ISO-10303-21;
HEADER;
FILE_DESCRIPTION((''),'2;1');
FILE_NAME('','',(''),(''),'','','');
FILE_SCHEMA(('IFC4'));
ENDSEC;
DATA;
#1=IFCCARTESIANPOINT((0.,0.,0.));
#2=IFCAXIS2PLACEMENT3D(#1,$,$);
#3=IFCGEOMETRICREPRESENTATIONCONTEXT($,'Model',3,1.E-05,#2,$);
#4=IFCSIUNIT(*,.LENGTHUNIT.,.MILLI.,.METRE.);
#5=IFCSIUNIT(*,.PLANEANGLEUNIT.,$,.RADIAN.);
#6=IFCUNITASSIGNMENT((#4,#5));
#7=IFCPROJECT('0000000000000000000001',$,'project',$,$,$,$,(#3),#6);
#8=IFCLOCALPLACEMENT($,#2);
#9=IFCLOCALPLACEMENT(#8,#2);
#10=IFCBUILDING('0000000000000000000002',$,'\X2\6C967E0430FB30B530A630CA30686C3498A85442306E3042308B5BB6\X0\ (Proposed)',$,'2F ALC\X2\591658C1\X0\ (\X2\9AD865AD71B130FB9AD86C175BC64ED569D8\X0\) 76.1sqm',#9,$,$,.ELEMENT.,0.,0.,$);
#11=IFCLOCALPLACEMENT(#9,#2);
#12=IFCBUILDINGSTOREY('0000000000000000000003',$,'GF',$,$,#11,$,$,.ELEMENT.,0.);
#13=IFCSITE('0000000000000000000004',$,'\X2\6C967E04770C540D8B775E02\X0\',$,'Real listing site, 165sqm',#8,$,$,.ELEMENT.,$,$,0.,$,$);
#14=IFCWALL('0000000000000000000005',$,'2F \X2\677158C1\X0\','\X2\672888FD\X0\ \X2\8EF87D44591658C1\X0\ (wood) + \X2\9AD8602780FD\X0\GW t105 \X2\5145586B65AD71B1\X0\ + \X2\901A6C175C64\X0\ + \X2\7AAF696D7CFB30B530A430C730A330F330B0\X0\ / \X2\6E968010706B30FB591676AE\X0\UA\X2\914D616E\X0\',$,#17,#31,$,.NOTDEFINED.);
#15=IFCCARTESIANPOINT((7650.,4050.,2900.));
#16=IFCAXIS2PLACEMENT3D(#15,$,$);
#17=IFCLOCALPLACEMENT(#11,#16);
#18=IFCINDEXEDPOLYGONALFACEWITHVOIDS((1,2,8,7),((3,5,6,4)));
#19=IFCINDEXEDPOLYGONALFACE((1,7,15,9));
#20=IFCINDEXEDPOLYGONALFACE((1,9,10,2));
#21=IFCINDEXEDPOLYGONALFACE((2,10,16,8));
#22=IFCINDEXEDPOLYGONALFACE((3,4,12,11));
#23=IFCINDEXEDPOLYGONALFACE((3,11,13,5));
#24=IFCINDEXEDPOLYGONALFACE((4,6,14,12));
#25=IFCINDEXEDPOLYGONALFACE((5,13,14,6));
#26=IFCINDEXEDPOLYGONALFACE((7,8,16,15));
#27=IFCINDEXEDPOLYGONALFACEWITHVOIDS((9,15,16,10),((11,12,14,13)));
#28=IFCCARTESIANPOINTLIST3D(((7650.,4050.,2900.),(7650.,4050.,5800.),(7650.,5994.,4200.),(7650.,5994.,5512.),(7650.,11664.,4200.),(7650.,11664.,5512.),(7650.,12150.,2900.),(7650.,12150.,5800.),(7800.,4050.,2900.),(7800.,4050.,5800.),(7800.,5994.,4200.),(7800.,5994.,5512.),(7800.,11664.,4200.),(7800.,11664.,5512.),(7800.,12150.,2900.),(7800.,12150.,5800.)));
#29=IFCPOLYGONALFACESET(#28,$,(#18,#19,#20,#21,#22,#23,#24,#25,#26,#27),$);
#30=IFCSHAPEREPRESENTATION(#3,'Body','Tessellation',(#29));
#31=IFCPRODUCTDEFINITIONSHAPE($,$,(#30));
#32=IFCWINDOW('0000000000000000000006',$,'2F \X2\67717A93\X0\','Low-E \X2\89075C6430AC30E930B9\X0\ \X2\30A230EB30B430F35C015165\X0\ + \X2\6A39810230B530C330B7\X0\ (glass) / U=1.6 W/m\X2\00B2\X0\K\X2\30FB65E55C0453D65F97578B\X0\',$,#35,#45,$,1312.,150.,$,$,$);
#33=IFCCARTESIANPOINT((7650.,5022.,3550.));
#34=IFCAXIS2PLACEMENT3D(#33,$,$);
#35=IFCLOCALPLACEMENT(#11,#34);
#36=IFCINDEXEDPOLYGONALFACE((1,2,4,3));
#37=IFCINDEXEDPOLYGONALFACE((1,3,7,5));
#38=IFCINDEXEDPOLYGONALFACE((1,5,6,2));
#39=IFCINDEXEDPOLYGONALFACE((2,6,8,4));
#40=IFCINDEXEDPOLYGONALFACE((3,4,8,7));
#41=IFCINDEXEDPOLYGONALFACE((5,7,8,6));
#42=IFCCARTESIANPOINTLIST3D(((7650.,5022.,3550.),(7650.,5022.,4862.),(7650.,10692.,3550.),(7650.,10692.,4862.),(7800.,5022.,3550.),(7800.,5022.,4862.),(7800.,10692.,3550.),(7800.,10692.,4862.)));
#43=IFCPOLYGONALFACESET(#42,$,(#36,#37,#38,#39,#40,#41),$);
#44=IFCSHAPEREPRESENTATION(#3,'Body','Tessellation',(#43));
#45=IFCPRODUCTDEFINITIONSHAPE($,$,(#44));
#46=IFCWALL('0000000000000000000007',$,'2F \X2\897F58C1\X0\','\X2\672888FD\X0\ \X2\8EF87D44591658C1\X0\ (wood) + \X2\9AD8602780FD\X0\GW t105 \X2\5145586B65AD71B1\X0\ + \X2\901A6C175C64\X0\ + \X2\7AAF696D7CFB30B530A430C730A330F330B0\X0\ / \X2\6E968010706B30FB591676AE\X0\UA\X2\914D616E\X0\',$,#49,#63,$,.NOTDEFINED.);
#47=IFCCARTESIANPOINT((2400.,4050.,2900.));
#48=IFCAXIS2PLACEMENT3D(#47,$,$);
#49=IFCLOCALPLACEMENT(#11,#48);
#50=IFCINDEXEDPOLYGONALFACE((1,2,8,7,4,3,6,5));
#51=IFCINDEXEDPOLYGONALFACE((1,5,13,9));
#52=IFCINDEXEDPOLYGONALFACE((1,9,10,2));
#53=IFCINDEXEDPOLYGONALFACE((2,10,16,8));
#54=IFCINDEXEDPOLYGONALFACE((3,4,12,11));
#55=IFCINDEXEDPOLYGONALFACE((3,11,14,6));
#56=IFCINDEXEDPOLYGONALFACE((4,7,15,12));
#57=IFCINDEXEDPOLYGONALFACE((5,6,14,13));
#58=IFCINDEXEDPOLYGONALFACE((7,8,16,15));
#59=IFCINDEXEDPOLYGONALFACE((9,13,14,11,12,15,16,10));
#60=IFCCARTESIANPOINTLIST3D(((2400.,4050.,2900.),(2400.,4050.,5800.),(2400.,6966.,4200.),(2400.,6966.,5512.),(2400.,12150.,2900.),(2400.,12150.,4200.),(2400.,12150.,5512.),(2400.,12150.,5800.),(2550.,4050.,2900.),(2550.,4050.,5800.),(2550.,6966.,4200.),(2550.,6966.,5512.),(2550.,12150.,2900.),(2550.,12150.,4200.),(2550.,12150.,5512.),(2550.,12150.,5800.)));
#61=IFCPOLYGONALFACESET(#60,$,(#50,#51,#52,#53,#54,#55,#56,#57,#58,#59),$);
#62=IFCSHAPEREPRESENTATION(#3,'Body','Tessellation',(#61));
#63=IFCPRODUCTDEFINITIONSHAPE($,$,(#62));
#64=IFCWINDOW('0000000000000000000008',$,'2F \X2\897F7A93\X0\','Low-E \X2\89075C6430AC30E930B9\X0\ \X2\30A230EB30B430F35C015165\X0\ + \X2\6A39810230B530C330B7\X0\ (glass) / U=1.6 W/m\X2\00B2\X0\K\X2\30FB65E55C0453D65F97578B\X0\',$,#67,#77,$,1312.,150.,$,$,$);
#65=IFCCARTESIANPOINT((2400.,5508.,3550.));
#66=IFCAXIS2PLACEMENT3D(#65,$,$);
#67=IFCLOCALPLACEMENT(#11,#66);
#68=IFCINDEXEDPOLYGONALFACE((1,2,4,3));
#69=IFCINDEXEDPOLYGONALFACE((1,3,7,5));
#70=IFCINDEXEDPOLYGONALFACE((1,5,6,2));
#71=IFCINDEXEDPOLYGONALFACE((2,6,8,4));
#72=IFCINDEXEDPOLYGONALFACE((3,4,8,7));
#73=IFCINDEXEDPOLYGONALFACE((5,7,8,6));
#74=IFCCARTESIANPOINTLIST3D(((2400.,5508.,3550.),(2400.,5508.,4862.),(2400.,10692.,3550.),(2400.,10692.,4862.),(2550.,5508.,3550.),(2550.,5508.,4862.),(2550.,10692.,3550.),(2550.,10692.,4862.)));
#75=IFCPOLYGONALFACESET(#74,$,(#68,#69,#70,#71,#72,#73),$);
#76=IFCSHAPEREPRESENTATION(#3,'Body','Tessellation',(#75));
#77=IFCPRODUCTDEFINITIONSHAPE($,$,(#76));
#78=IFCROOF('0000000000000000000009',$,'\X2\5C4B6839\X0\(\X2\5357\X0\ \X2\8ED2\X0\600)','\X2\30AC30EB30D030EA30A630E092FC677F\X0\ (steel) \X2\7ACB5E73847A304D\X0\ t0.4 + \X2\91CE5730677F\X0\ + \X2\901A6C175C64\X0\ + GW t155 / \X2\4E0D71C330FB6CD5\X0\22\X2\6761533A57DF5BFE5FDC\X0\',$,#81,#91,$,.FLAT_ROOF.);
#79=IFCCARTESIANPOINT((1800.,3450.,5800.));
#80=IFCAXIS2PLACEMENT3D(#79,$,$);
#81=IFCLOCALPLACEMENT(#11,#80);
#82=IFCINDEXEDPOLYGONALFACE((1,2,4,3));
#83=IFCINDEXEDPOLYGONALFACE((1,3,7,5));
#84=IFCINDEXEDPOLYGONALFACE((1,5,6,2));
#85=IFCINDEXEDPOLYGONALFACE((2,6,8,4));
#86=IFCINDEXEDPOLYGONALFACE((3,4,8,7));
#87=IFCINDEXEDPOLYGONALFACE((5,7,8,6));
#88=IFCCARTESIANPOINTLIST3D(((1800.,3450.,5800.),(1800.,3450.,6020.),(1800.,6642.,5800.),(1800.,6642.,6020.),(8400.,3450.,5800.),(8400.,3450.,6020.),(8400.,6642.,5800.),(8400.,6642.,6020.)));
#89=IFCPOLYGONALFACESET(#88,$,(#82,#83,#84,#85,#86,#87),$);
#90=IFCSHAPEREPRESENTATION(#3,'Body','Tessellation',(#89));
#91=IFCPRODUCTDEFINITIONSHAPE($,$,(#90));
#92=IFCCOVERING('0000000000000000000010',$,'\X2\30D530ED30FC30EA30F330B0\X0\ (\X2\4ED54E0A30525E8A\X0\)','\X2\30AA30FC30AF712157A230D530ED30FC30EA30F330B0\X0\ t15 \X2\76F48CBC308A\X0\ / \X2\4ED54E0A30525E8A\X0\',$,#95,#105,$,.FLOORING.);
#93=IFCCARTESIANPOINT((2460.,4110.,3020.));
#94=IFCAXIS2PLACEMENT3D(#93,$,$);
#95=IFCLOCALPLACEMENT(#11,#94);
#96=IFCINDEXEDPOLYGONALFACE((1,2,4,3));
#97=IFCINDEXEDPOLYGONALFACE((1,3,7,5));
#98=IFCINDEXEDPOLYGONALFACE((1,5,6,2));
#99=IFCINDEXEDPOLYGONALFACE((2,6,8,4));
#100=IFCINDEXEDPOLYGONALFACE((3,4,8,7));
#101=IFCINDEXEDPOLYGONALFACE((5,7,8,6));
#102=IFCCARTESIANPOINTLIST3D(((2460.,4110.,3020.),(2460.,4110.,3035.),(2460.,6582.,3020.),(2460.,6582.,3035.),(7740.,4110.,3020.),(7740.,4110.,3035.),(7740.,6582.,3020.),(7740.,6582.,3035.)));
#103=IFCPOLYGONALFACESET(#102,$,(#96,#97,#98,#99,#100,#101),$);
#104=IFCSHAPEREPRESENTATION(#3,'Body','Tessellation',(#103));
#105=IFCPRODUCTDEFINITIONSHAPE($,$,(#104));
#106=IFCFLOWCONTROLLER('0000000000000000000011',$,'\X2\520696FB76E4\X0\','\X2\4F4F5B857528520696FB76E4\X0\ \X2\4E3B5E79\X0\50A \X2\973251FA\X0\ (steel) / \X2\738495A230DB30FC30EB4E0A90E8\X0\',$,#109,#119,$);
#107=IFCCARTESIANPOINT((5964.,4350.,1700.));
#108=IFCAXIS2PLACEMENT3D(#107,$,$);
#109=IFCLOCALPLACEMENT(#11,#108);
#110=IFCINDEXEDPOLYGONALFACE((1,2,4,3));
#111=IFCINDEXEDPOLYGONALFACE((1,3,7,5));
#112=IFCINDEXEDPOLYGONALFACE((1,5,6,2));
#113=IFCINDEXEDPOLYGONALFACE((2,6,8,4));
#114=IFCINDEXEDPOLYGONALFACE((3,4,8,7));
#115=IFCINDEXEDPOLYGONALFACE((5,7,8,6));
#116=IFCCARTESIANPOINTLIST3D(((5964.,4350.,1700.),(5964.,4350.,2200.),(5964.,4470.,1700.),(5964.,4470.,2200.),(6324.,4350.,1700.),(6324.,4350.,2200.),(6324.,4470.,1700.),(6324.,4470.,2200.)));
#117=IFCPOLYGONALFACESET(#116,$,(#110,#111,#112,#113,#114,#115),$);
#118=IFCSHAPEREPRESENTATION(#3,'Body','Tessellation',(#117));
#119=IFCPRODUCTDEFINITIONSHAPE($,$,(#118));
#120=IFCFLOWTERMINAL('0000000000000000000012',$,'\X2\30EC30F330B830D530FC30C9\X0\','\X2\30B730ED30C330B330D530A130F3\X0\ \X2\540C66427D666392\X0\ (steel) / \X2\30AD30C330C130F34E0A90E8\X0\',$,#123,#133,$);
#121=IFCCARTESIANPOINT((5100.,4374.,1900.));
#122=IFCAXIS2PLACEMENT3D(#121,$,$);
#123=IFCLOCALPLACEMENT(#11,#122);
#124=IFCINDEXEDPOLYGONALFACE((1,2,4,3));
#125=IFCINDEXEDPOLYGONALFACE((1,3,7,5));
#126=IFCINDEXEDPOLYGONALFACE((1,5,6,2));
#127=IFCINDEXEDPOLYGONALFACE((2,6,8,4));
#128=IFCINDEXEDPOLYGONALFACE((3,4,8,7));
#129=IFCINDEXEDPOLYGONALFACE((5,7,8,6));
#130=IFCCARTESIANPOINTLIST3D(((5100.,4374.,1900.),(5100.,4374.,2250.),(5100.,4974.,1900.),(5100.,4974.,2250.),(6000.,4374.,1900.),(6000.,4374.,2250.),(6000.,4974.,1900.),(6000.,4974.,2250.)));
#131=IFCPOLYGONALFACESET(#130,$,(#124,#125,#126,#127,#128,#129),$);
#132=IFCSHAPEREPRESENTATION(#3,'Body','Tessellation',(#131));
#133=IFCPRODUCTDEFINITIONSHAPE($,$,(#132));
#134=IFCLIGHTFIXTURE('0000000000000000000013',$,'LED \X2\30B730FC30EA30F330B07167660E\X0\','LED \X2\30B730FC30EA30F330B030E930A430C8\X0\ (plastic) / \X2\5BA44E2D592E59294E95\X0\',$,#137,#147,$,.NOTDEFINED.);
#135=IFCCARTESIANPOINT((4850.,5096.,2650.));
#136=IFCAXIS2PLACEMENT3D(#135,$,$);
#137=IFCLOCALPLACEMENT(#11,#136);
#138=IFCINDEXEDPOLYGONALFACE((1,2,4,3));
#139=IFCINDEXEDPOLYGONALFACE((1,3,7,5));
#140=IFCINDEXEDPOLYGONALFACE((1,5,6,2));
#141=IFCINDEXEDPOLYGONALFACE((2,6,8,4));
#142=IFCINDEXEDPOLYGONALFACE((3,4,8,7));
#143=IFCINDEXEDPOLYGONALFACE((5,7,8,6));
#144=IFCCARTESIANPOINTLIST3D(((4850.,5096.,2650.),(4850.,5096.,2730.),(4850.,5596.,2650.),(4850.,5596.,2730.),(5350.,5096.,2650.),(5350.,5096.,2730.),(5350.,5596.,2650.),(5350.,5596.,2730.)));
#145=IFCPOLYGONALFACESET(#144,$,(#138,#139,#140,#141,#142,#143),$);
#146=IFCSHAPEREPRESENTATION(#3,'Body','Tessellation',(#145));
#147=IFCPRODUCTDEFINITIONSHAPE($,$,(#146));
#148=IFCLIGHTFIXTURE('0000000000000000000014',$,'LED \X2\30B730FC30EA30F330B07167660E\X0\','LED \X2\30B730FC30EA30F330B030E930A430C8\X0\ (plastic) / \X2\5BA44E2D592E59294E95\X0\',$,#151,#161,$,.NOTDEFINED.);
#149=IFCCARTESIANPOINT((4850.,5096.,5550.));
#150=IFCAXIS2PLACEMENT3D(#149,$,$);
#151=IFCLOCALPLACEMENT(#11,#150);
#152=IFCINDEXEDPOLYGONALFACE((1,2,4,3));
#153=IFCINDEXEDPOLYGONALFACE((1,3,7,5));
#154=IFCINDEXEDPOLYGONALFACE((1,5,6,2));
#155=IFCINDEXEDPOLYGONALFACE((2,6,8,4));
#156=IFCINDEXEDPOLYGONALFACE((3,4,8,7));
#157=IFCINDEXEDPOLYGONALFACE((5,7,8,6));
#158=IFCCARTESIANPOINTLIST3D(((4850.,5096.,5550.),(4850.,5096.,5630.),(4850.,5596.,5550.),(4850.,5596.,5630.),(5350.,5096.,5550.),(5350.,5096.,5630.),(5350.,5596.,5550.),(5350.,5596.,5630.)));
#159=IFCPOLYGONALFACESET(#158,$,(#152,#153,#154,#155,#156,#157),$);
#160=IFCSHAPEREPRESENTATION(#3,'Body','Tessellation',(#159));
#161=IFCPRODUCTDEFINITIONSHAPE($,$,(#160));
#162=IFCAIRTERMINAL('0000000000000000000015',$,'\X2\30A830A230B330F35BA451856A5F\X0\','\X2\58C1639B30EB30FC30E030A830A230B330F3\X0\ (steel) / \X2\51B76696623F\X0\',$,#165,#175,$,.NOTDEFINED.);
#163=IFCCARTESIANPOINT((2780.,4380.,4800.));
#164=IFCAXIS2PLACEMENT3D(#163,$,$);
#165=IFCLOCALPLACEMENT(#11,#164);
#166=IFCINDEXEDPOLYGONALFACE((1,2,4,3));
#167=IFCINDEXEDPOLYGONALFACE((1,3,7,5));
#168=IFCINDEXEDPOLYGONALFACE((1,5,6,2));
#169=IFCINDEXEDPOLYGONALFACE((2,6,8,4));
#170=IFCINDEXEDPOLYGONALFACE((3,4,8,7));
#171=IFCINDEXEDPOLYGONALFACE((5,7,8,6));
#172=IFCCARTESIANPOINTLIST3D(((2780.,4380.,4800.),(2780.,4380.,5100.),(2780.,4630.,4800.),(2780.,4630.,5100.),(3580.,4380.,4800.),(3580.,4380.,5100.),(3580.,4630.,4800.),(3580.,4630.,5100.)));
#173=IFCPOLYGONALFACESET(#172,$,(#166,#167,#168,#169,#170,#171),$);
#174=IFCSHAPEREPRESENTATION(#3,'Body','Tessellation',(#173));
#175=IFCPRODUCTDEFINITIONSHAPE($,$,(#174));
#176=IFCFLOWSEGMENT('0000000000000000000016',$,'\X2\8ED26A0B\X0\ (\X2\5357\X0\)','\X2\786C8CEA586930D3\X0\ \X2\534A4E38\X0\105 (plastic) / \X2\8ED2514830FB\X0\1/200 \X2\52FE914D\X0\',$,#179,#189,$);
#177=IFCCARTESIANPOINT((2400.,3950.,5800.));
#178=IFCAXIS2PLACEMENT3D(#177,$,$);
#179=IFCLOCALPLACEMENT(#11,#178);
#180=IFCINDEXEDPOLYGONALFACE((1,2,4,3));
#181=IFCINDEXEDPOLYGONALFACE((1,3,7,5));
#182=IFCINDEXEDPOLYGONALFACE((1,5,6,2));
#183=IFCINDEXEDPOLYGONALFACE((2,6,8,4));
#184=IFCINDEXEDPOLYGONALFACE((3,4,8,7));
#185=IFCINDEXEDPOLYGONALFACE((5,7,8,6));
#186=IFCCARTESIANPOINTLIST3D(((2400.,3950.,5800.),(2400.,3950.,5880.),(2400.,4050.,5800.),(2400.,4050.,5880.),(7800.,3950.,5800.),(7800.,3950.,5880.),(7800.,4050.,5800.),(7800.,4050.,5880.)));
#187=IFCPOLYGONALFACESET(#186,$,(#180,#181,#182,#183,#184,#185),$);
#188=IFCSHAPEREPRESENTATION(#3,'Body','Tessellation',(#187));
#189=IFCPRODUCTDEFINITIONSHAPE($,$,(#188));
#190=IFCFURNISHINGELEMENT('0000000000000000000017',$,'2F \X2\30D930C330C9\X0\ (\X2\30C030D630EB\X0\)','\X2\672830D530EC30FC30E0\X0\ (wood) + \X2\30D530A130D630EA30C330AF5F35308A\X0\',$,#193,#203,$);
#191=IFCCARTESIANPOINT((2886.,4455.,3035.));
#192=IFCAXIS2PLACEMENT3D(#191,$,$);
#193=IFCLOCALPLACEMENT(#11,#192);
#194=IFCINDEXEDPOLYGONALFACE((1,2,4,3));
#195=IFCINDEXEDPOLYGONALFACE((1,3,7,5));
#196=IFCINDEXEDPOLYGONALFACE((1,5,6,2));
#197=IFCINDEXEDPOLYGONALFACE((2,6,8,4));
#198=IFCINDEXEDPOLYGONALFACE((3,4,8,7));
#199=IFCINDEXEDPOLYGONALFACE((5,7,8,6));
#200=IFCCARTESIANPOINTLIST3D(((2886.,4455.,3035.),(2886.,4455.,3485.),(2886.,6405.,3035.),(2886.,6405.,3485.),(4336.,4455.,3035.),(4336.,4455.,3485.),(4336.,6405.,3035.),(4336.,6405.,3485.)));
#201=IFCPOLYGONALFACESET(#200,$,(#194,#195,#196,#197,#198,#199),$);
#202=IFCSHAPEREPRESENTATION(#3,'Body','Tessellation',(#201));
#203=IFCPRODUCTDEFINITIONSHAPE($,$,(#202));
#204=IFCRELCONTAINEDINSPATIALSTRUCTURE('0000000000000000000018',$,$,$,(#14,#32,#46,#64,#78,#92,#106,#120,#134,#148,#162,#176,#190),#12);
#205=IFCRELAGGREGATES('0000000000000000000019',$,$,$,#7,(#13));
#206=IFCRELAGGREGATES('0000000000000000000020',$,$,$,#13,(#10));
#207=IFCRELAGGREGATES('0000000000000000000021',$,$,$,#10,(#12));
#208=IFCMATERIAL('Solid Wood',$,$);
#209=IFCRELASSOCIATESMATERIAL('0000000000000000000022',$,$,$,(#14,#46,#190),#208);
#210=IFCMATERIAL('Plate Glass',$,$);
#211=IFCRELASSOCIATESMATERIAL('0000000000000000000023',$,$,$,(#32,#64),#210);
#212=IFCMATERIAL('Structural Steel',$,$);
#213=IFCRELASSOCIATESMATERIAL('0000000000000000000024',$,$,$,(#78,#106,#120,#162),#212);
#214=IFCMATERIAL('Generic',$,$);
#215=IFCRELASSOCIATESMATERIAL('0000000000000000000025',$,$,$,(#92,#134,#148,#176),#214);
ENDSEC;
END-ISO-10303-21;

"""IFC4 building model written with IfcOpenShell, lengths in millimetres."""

from ifc_helpers import new_model, si_unit, frame, frame_2d, origin, place, context, project, spatial, rectangle, extrude, material, element, fill, save


model = new_model("IFC4")

# Units and contexts
model_context = context("Model", 3, precision=1e-05, world=origin())
ifc_project = project(units=[si_unit("LENGTHUNIT", "METRE", prefix="MILLI"), si_unit("PLANEANGLEUNIT", "RADIAN")], contexts=[model_context])

# Site, building, storey
site_placement = place(None, origin())
site = spatial("IfcSite", under=ifc_project, at=site_placement, Name="沖縄県名護市", ObjectType="Real listing site, 165sqm", CompositionType="ELEMENT", RefElevation=0.0)
building_placement = place(site_placement, origin())
building = spatial("IfcBuilding", under=site, at=building_placement, Name="沖縄・サウナと水風呂のある家 (Proposed)", ObjectType="2F ALC外壁 (高断熱・高気密仕様) 76.1sqm", CompositionType="ELEMENT", ElevationOfRefHeight=0.0, ElevationOfTerrain=0.0)
storey_placement = place(building_placement, origin())
storey = spatial("IfcBuildingStorey", under=building, at=storey_placement, Name="GF", CompositionType="ELEMENT", Elevation=0.0)

# Shared definitions
ifc_material_1 = material(Name="Solid Wood")

# Shared definitions
ifc_material_2 = material(Name="Plate Glass")

# Walls, openings, windows
wall_1_placement = place(storey_placement, frame((7650.0, 4050.0, 2900.0)))
wall_1 = element("IfcWall", 1, at=wall_1_placement, inside=storey, material=ifc_material_1, Name="2F 東壁", Description="木製 軸組外壁 (wood) + 高性能GW t105 充填断熱 + 通気層 + 窯業系サイディング / 準耐火・外皮UA配慮", PredefinedType="NOTDEFINED", context=model_context, shape_type="SweptSolid", body=[
    extrude(rectangle(XDim=150.0, YDim=8100.0, at=frame_2d((75.0, 4050.0))), frame((7650.0, 4050.0, 2900.0)), (0.0, 0.0, 1.0), 2900.0),
])
opening_1_placement = place(storey_placement, frame((7650.0, 5022.0, 3550.0)))
opening_1 = element("IfcOpeningElement", 2, at=opening_1_placement, cuts=wall_1, PredefinedType="NOTDEFINED", context=model_context, shape_type="SweptSolid", body=[
    extrude(rectangle(XDim=150.0, YDim=5670.0, at=frame_2d((75.0, 2835.0))), frame((7650.0, 5022.0, 3550.0)), (0.0, 0.0, 1.0), 1312.0),
])
window_1_placement = place(storey_placement, frame((7650.0, 5022.0, 3550.0)))
window_1 = element("IfcWindow", 3, at=window_1_placement, inside=storey, material=ifc_material_2, Name="2F 東窓", Description="Low-E 複層ガラス アルゴン封入 + 樹脂サッシ (glass) / U=1.6 W/m²K・日射取得型", OverallHeight=1312.0, OverallWidth=150.0, context=model_context, shape_type="SweptSolid", body=[
    extrude(rectangle(XDim=150.0, YDim=5670.0, at=frame_2d((75.0, 2835.0))), frame((7650.0, 5022.0, 3550.0)), (0.0, 0.0, 1.0), 1312.0),
])
fill(opening_1, window_1)
wall_2_placement = place(storey_placement, frame((2400.0, 4050.0, 2900.0)))
wall_2 = element("IfcWall", 4, at=wall_2_placement, inside=storey, material=ifc_material_1, Name="2F 西壁", Description="木製 軸組外壁 (wood) + 高性能GW t105 充填断熱 + 通気層 + 窯業系サイディング / 準耐火・外皮UA配慮", PredefinedType="NOTDEFINED", context=model_context, shape_type="SweptSolid", body=[
    extrude(rectangle(XDim=150.0, YDim=8100.0, at=frame_2d((75.0, 4050.0))), frame((2400.0, 4050.0, 2900.0)), (0.0, 0.0, 1.0), 2900.0),
])
opening_2_placement = place(storey_placement, frame((2400.0, 5508.0, 3550.0)))
opening_2 = element("IfcOpeningElement", 5, at=opening_2_placement, cuts=wall_2, PredefinedType="NOTDEFINED", context=model_context, shape_type="SweptSolid", body=[
    extrude(rectangle(XDim=150.0, YDim=5184.0, at=frame_2d((75.0, 2592.0))), frame((2400.0, 5508.0, 3550.0)), (0.0, 0.0, 1.0), 1312.0),
])
window_2_placement = place(storey_placement, frame((2400.0, 5508.0, 3550.0)))
window_2 = element("IfcWindow", 6, at=window_2_placement, inside=storey, material=ifc_material_2, Name="2F 西窓", Description="Low-E 複層ガラス アルゴン封入 + 樹脂サッシ (glass) / U=1.6 W/m²K・日射取得型", OverallHeight=1312.0, OverallWidth=150.0, context=model_context, shape_type="SweptSolid", body=[
    extrude(rectangle(XDim=150.0, YDim=5184.0, at=frame_2d((75.0, 2592.0))), frame((2400.0, 5508.0, 3550.0)), (0.0, 0.0, 1.0), 1312.0),
])
fill(opening_2, window_2)

# Roof
ifc_material_3 = material(Name="Structural Steel")
for number, where, name in (
    (7, (1800.0, 3450.0, 5800.0), "屋根(南 軒600)"),
):
    element("IfcRoof", number, at=place(storey_placement, frame(where)), inside=storey, material=ifc_material_3, Name=name, Description="ガルバリウム鋼板 (steel) 立平葺き t0.4 + 野地板 + 通気層 + GW t155 / 不燃・法22条区域対応", PredefinedType="FLAT_ROOF", context=model_context, shape_type="SweptSolid", body=[
        extrude(rectangle(XDim=6600.0, YDim=3192.0, at=frame_2d((3300.0, 1596.0))), frame((1800.0, 3450.0, 5800.0)), (0.0, 0.0, 1.0), 220.0),
    ])

# Covering
ifc_material_4 = material(Name="Generic")
covering_placement = place(storey_placement, frame((2460.0, 4110.0, 3020.0)))
element("IfcCovering", 8, at=covering_placement, inside=storey, material=ifc_material_4, Name="フローリング (仕上げ床)", Description="オーク無垢フローリング t15 直貼り / 仕上げ床", PredefinedType="FLOORING", context=model_context, shape_type="SweptSolid", body=[
    extrude(rectangle(XDim=5280.0, YDim=2472.0, at=frame_2d((2640.0, 1236.0))), frame((2460.0, 4110.0, 3020.0)), (0.0, 0.0, 1.0), 15.0),
])

# Flow controller
flow_controller_placement = place(storey_placement, frame((5964.0, 4350.0, 1700.0)))
element("IfcFlowController", 9, at=flow_controller_placement, inside=storey, material=ifc_material_3, Name="分電盤", Description="住宅用分電盤 主幹50A 露出 (steel) / 玄関ホール上部", context=model_context, shape_type="SweptSolid", body=[
    extrude(rectangle(XDim=360.0, YDim=120.0, at=frame_2d((180.0, 60.0))), frame((5964.0, 4350.0, 1700.0)), (0.0, 0.0, 1.0), 500.0),
])

# Flow terminal
flow_terminal_placement = place(storey_placement, frame((5100.0, 4374.0, 1900.0)))
element("IfcFlowTerminal", 10, at=flow_terminal_placement, inside=storey, material=ifc_material_3, Name="レンジフード", Description="シロッコファン 同時給排 (steel) / キッチン上部", context=model_context, shape_type="SweptSolid", body=[
    extrude(rectangle(XDim=900.0, YDim=600.0, at=frame_2d((450.0, 300.0))), frame((5100.0, 4374.0, 1900.0)), (0.0, 0.0, 1.0), 350.0),
])

# Light fixtures
light_fixture_1_placement = place(storey_placement, frame((4850.0, 5096.0, 2650.0)))
element("IfcLightFixture", 11, at=light_fixture_1_placement, inside=storey, material=ifc_material_4, Name="LED シーリング照明", Description="LED シーリングライト (plastic) / 室中央天井", PredefinedType="NOTDEFINED", context=model_context, shape_type="SweptSolid", body=[
    extrude(rectangle(XDim=500.0, YDim=500.0, at=frame_2d((250.0, 250.0))), frame((4850.0, 5096.0, 2650.0)), (0.0, 0.0, 1.0), 80.0),
])
light_fixture_2_placement = place(storey_placement, frame((4850.0, 5096.0, 5550.0)))
element("IfcLightFixture", 12, at=light_fixture_2_placement, inside=storey, material=ifc_material_4, Name="LED シーリング照明", Description="LED シーリングライト (plastic) / 室中央天井", PredefinedType="NOTDEFINED", context=model_context, shape_type="SweptSolid", body=[
    extrude(rectangle(XDim=500.0, YDim=500.0, at=frame_2d((250.0, 250.0))), frame((4850.0, 5096.0, 5550.0)), (0.0, 0.0, 1.0), 80.0),
])

# Air terminal
air_terminal_placement = place(storey_placement, frame((2780.0, 4380.0, 4800.0)))
element("IfcAirTerminal", 13, at=air_terminal_placement, inside=storey, material=ifc_material_3, Name="エアコン室内機", Description="壁掛ルームエアコン (steel) / 冷暖房", PredefinedType="NOTDEFINED", context=model_context, shape_type="SweptSolid", body=[
    extrude(rectangle(XDim=800.0, YDim=250.0, at=frame_2d((400.0, 125.0))), frame((2780.0, 4380.0, 4800.0)), (0.0, 0.0, 1.0), 300.0),
])

# Flow segment
flow_segment_placement = place(storey_placement, frame((2400.0, 3950.0, 5800.0)))
element("IfcFlowSegment", 14, at=flow_segment_placement, inside=storey, material=ifc_material_4, Name="軒樋 (南)", Description="硬質塩ビ 半丸105 (plastic) / 軒先・1/200 勾配", context=model_context, shape_type="SweptSolid", body=[
    extrude(rectangle(XDim=5400.0, YDim=100.0, at=frame_2d((2700.0, 50.0))), frame((2400.0, 3950.0, 5800.0)), (0.0, 0.0, 1.0), 80.0),
])

# Furnishing element
furnishing_1_placement = place(storey_placement, frame((2886.0, 4455.0, 3035.0)))
element("IfcFurnishingElement", 15, at=furnishing_1_placement, inside=storey, material=ifc_material_1, Name="2F ベッド (ダブル)", Description="木フレーム (wood) + ファブリック張り", context=model_context, shape_type="SweptSolid", body=[
    extrude(rectangle(XDim=1450.0, YDim=1950.0, at=frame_2d((725.0, 975.0))), frame((2886.0, 4455.0, 3035.0)), (0.0, 0.0, 1.0), 450.0),
])

save(model, "model.ifc")
